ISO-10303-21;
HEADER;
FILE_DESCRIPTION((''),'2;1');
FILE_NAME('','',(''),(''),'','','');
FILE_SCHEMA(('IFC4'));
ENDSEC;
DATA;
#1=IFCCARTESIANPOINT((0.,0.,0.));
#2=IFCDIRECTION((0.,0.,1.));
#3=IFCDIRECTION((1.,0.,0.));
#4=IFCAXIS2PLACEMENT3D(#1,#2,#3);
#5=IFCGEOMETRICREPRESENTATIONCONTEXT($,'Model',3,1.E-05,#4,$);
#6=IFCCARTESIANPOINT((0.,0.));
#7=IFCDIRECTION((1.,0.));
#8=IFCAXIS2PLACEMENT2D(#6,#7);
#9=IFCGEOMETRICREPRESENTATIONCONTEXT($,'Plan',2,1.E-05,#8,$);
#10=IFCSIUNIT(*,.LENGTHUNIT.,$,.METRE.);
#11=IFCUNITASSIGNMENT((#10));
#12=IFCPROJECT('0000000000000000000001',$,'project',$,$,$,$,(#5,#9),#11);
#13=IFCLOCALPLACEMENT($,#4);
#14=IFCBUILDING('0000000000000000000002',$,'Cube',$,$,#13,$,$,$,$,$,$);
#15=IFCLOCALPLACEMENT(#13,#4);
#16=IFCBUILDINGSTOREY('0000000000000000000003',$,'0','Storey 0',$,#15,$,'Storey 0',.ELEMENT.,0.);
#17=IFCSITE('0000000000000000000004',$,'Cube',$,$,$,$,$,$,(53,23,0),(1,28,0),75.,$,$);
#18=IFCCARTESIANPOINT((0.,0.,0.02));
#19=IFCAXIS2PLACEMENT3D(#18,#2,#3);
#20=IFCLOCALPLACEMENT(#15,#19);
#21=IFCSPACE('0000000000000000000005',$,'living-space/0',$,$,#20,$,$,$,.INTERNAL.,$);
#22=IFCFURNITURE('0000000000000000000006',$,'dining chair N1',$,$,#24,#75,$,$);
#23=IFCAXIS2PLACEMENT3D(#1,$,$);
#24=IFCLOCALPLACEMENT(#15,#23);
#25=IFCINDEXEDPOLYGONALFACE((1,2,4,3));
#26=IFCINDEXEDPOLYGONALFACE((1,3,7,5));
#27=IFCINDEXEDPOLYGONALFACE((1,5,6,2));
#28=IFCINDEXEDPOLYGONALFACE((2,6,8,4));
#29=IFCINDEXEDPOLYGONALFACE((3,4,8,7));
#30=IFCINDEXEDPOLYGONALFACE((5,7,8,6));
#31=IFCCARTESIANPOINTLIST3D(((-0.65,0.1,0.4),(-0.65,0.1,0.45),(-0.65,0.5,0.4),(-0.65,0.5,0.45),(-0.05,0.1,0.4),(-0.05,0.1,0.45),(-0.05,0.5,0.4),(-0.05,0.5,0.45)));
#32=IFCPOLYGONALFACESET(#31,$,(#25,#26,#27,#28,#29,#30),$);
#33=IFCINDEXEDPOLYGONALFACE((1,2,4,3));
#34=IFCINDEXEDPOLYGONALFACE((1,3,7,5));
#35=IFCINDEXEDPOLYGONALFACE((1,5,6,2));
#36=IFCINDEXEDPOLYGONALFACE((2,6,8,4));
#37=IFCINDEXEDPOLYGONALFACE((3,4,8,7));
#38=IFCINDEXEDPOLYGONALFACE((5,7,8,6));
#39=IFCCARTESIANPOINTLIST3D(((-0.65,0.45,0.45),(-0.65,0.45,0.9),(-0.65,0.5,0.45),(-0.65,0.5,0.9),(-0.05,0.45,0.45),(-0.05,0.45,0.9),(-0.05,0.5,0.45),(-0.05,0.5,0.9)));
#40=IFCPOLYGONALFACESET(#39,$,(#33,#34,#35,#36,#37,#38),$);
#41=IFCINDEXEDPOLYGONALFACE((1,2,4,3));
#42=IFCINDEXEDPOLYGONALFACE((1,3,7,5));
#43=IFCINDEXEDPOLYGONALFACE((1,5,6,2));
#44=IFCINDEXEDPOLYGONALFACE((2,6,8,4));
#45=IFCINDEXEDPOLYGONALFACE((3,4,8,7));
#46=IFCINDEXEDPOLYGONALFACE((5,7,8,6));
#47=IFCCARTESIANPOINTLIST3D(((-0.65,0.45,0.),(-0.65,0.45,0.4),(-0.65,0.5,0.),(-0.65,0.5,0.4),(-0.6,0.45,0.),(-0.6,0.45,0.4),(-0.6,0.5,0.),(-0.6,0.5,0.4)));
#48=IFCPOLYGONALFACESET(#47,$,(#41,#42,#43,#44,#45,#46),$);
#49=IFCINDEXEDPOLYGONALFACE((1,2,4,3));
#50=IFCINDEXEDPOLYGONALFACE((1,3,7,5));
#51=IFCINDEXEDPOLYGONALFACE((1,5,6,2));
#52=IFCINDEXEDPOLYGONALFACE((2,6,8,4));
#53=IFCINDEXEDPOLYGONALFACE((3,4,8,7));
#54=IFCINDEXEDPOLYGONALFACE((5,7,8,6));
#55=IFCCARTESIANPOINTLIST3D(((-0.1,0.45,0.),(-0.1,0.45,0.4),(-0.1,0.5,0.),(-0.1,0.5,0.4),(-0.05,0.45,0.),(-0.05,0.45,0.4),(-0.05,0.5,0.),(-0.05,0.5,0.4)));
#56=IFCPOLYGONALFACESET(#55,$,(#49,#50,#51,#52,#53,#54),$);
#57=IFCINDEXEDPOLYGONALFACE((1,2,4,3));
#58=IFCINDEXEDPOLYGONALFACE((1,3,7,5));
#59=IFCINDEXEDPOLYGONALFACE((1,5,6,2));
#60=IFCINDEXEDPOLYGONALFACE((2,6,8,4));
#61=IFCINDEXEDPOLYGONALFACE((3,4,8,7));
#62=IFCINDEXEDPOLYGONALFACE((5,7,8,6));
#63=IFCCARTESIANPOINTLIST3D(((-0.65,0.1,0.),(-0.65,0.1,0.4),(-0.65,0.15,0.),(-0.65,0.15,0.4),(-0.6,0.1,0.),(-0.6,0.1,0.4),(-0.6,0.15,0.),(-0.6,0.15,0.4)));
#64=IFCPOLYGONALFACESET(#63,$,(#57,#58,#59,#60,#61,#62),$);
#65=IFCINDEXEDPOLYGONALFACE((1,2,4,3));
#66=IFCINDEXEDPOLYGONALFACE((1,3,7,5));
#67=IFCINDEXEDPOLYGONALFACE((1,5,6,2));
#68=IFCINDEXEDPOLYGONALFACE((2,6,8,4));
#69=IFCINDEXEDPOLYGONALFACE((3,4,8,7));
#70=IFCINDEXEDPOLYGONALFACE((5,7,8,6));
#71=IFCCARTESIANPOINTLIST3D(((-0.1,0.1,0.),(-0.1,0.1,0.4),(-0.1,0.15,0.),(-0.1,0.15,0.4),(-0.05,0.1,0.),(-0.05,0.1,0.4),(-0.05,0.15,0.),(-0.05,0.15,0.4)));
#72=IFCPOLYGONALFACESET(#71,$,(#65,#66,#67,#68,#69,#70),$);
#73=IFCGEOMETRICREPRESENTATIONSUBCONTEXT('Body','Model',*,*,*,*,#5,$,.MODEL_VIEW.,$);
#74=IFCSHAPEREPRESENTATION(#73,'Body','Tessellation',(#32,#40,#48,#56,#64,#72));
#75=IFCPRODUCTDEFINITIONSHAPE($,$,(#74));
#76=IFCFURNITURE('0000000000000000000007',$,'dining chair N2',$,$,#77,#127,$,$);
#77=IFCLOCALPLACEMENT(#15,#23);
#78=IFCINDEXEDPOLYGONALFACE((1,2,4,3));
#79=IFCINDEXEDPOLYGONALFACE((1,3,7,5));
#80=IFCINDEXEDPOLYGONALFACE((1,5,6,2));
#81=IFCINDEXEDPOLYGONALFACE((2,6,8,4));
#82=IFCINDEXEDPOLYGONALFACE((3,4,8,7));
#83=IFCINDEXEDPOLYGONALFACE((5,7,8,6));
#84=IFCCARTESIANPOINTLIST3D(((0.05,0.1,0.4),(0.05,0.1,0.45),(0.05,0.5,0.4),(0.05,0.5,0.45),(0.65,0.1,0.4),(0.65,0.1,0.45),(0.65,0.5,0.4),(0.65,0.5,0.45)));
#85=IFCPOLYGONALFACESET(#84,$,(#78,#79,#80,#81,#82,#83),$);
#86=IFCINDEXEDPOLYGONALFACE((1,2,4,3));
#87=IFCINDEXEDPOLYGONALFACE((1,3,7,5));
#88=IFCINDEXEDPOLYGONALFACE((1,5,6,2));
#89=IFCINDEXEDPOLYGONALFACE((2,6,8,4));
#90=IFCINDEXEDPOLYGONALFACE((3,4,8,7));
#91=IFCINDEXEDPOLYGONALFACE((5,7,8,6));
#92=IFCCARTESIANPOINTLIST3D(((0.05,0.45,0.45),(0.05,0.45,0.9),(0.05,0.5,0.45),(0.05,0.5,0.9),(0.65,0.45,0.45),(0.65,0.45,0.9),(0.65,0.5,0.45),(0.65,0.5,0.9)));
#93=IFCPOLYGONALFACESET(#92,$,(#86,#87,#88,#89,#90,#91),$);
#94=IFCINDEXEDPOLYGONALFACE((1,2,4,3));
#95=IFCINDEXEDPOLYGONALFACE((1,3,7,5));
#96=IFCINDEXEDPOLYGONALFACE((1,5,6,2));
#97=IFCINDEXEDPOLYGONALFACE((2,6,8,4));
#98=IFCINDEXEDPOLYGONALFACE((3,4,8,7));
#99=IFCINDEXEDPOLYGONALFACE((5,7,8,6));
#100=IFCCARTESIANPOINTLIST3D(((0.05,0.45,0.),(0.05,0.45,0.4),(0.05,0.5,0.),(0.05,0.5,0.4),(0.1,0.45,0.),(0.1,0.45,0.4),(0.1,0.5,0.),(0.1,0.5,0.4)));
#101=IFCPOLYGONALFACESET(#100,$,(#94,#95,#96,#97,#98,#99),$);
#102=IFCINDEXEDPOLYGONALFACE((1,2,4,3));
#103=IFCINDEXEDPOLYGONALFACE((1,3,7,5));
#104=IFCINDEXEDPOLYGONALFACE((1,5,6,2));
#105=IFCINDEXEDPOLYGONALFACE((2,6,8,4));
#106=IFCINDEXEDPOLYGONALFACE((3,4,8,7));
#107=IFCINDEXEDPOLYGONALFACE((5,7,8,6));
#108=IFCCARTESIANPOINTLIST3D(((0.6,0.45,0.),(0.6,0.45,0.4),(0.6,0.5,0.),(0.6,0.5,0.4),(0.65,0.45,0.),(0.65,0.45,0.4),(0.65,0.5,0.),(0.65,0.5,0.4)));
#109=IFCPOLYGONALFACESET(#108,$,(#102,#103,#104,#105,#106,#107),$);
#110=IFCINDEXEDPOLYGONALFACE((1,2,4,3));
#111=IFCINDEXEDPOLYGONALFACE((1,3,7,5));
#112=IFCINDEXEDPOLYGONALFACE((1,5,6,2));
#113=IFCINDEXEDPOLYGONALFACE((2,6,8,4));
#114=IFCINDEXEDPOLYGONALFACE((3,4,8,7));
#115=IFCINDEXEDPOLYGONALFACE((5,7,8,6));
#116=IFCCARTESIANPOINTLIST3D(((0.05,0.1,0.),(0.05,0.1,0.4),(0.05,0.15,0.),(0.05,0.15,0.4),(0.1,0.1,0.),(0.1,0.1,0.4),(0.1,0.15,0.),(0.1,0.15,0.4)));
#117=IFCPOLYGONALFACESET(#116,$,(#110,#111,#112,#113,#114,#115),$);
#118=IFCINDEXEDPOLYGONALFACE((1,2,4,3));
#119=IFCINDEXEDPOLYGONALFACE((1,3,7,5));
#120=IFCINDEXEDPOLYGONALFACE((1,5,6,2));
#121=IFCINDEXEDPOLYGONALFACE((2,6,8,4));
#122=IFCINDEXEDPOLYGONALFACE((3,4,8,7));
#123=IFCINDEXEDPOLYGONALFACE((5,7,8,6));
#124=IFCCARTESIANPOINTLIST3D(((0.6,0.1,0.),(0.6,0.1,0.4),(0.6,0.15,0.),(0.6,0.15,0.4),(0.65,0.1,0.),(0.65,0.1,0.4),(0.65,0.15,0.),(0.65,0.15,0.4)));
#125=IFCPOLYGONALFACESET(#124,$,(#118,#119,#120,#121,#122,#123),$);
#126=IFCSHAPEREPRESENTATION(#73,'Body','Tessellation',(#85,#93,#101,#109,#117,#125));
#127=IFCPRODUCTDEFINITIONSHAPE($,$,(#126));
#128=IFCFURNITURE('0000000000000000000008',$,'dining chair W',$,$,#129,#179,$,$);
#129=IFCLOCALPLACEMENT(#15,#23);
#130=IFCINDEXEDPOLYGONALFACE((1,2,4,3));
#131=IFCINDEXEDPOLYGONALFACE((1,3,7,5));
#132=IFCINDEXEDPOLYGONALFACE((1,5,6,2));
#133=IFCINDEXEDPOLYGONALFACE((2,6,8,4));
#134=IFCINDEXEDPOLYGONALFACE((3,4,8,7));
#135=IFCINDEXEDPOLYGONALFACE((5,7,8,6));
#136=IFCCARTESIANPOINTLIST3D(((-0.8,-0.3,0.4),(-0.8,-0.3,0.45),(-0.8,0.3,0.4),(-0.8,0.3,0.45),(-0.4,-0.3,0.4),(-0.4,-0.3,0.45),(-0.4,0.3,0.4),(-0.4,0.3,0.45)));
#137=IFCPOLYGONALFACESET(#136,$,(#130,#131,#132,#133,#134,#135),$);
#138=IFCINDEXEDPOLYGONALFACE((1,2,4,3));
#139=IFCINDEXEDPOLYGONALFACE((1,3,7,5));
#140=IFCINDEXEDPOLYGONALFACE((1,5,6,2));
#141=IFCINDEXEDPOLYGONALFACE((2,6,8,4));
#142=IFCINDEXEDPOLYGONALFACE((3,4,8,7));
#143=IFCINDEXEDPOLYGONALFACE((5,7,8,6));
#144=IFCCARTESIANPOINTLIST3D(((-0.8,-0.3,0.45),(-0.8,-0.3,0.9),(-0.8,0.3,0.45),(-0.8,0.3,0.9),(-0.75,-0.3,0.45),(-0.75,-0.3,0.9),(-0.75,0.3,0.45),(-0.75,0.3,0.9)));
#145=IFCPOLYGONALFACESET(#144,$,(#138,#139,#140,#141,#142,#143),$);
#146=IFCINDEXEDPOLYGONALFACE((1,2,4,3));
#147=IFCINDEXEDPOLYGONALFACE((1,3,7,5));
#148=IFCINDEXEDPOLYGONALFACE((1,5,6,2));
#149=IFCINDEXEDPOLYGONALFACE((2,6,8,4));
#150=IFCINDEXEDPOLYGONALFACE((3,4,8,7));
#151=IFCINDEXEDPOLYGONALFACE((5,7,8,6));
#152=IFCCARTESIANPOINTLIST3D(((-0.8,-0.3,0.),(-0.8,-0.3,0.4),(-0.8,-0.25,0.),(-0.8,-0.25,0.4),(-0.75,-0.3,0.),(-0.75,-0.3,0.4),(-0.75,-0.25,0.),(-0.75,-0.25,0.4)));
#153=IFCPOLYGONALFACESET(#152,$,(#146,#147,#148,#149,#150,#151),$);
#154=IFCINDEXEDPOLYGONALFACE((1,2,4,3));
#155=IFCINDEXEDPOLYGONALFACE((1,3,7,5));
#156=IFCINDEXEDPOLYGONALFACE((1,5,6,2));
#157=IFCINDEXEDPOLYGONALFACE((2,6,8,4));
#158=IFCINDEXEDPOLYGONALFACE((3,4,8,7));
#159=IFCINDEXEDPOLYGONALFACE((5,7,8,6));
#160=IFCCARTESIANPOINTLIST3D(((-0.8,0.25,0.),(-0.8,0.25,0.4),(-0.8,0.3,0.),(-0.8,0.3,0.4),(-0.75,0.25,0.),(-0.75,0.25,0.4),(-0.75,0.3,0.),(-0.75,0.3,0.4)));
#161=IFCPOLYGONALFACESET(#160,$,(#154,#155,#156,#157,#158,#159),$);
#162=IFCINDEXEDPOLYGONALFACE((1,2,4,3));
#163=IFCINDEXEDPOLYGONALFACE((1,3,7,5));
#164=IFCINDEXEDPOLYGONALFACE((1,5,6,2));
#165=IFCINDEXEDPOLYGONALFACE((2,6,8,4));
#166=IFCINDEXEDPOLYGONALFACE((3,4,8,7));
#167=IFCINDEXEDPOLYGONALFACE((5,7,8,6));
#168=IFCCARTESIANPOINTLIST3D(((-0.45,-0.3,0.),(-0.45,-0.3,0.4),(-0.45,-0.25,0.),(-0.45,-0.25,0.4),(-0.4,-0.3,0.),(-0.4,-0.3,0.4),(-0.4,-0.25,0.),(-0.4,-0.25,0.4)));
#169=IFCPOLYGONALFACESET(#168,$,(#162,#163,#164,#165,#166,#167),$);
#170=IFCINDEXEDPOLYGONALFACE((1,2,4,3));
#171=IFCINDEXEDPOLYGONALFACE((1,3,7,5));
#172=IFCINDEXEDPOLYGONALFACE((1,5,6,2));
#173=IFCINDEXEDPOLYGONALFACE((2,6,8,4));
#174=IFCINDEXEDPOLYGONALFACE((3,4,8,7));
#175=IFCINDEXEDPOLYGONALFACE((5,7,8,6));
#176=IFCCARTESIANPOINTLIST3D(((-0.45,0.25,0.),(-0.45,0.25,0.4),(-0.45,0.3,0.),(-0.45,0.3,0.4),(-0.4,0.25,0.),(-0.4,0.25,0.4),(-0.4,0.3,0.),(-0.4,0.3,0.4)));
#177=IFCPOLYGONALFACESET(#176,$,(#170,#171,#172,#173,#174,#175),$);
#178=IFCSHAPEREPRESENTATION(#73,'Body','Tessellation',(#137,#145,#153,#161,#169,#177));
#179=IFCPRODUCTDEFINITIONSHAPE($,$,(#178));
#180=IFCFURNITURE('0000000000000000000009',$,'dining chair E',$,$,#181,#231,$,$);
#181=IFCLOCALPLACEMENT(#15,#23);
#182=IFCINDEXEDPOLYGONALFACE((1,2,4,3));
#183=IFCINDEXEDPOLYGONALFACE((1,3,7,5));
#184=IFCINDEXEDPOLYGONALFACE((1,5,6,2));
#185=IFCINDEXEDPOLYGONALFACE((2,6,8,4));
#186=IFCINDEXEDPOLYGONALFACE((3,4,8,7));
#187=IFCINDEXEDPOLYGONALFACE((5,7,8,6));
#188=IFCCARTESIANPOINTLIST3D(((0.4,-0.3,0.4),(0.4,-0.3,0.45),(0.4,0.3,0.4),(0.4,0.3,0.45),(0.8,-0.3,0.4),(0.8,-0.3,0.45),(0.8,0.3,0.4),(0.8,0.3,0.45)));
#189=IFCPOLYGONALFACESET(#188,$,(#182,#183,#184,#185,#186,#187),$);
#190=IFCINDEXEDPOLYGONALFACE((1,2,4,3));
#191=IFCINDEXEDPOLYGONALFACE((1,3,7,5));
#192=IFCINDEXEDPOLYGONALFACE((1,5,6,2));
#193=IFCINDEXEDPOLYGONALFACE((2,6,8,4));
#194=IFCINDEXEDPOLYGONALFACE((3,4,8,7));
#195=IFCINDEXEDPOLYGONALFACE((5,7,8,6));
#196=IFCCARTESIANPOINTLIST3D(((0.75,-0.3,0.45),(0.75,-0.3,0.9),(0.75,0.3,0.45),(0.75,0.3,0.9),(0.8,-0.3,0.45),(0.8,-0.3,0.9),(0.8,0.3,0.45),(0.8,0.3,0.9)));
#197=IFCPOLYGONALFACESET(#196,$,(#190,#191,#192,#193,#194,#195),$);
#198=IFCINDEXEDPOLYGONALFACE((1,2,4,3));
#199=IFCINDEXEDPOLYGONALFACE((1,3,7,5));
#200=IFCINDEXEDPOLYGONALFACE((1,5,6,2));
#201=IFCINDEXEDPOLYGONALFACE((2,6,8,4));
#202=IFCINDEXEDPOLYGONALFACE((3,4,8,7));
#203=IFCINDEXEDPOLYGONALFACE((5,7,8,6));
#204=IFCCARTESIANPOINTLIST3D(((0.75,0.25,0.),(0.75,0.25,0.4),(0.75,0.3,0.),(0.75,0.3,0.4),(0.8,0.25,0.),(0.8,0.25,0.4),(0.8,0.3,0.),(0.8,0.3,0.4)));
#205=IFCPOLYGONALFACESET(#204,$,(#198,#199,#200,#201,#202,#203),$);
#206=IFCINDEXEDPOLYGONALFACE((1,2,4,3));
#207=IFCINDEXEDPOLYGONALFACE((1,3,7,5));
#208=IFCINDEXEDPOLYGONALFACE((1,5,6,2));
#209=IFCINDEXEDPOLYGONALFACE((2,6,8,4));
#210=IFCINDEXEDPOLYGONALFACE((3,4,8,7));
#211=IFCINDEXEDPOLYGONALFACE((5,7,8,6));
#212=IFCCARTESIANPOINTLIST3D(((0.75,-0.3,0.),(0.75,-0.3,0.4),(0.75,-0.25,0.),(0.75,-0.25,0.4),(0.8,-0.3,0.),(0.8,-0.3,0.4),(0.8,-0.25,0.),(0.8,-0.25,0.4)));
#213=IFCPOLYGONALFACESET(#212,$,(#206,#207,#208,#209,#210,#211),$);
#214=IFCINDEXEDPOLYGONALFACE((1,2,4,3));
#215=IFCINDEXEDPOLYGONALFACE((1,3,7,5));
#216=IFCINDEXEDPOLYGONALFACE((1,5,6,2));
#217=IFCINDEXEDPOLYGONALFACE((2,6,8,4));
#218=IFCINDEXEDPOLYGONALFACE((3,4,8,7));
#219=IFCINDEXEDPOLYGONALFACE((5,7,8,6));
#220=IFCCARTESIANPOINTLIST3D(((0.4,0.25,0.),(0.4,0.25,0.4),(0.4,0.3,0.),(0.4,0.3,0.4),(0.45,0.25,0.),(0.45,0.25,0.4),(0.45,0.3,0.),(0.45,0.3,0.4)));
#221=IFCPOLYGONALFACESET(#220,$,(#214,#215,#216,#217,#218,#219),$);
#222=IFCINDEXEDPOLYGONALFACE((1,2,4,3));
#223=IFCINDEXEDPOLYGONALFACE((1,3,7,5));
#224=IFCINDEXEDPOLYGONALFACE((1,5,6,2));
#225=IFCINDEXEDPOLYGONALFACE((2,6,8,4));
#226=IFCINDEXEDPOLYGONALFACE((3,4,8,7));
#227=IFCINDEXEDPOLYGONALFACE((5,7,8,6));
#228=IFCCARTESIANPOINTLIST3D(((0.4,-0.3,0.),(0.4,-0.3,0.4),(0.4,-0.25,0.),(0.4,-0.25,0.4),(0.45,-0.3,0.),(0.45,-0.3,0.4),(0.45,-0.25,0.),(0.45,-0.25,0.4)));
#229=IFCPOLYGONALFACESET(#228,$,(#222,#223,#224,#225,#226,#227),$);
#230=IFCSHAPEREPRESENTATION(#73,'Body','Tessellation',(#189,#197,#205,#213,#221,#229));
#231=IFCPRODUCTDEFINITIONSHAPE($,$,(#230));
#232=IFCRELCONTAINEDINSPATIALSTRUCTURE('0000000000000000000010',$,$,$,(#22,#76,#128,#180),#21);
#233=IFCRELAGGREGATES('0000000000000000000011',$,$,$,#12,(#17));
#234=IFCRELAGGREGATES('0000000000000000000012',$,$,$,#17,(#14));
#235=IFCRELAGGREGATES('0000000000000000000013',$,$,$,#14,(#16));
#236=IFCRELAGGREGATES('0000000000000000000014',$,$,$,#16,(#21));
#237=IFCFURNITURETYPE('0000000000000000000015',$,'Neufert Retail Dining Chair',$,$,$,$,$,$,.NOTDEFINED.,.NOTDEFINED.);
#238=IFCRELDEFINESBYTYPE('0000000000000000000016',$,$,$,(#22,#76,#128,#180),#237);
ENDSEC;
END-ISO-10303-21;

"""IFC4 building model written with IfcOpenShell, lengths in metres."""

from ifc_helpers import new_model, entity, si_unit, frame, origin_with_axes, origin_2d_with_axis, place, context, subcontext, project, spatial, line, indexed_curve, outline, extrude, shape, source, transform, mapped, type_object, type_shapes, element, save


model = new_model("IFC4")

# Units and contexts
model_context = context("Model", 3, precision=1e-05, world=origin_with_axes())
plan_context = context("Plan", 2, precision=1e-05, world=origin_2d_with_axis())
body_context_1 = subcontext(model_context, "Body", "Model", "MODEL_VIEW")
body_context_2 = subcontext(plan_context, "Body", "Plan", "PLAN_VIEW")
ifc_project = project(units=[si_unit("LENGTHUNIT", "METRE")], contexts=[model_context, plan_context])

# Site, building, storey
site = spatial("IfcSite", under=ifc_project, Name="Cube", RefLatitude=(53, 23, 0), RefLongitude=(1, 28, 0), RefElevation=75.0)
building_placement = place(None, origin_with_axes())
building = spatial("IfcBuilding", under=site, at=building_placement, Name="Cube")
storey_placement = place(building_placement, origin_with_axes())
storey = spatial("IfcBuildingStorey", under=building, at=storey_placement, Name="0", Description="Storey 0", LongName="Storey 0", CompositionType="ELEMENT", Elevation=0.0)

# Shared definitions
space_placement = place(storey_placement, frame((0.0, 0.0, 0.02), z_axis=(0.0, 0.0, 1.0), x_axis=(1.0, 0.0, 0.0)))
space = spatial("IfcSpace", under=storey, at=space_placement, Name="living-space/0", PredefinedType="INTERNAL")

# Furniture
furniture_type_1 = type_object("IfcFurnitureType", Name="Neufert Retail Dining Chair", AssemblyPlace="NOTDEFINED", PredefinedType="NOTDEFINED")
shared_shape_1 = source(origin_with_axes(), body_context_1, "Body", "SweptSolid", [
    extrude(outline(indexed_curve([(-0.3, 0.0), (0.3, 0.0), (0.3, -0.4), (-0.3, -0.4)], segments=[line(1, 2, 3, 4, 1)])), frame((0.0, 0.0, 0.45), z_axis=(0.0, 0.0, 1.0), x_axis=(1.0, 0.0, 0.0)), (0.0, 0.0, -1.0), 0.05),
    extrude(outline(indexed_curve([(-0.3, 0.0), (0.3, 0.0), (0.3, -0.05), (-0.3, -0.05)], segments=[line(1, 2, 3, 4, 1)])), frame((0.0, 0.0, 0.9), z_axis=(0.0, 0.0, 1.0), x_axis=(1.0, 0.0, 0.0)), (0.0, 0.0, -1.0), 0.45),
    extrude(outline(indexed_curve([(-0.3, 0.0), (-0.25, 0.0), (-0.25, -0.05), (-0.3, -0.05)], segments=[line(1, 2, 3, 4, 1)])), origin_with_axes(), (0.0, 0.0, 1.0), 0.4),
    extrude(outline(indexed_curve([(0.3, 0.0), (0.25, 0.0), (0.25, -0.05), (0.3, -0.05)], segments=[line(1, 2, 3, 4, 1)])), origin_with_axes(), (0.0, 0.0, 1.0), 0.4),
    extrude(outline(indexed_curve([(-0.3, -0.4), (-0.25, -0.4), (-0.25, -0.35), (-0.3, -0.35)], segments=[line(1, 2, 3, 4, 1)])), origin_with_axes(), (0.0, 0.0, 1.0), 0.4),
    extrude(outline(indexed_curve([(0.3, -0.4), (0.25, -0.4), (0.25, -0.35), (0.3, -0.35)], segments=[line(1, 2, 3, 4, 1)])), origin_with_axes(), (0.0, 0.0, 1.0), 0.4),
])
shared_shape_2 = source(origin_with_axes(), body_context_2, "Body", "Curve2D", [
    entity("IfcIndexedPolyCurve", entity("IfcCartesianPointList2D", [[-0.3, -0.4], [0.3, -0.4]])),
    entity("IfcIndexedPolyCurve", entity("IfcCartesianPointList2D", [[-0.3, -0.4], [-0.3, -0.3], [-0.2121, -0.0879], [0.0, 0.0], [0.2121, -0.0879], [0.3, -0.3], [0.3, -0.4]]), [entity("IfcLineIndex", [1, 2]), entity("IfcArcIndex", [2, 3, 4]), entity("IfcArcIndex", [4, 5, 6]), entity("IfcLineIndex", [6, 7])]),
    entity("IfcIndexedPolyCurve", entity("IfcCartesianPointList2D", [[-0.26, -0.4], [-0.26, -0.3], [-0.1838, -0.1162], [0.0, -0.04], [0.1838, -0.1162], [0.26, -0.3], [0.26, -0.4]]), [entity("IfcLineIndex", [1, 2]), entity("IfcArcIndex", [2, 3, 4]), entity("IfcArcIndex", [4, 5, 6]), entity("IfcLineIndex", [6, 7])]),
])
type_shapes(furniture_type_1, [shared_shape_1, shared_shape_2])
for number, where, z_axis, x_axis, name in (
    (1, (-0.35, 0.5, -0.02), (0.0, 0.0, 1.0), (1.0, 0.0, 0.0), "dining chair N1"),
    (2, (0.35, 0.5, -0.02), (0.0, 0.0, 1.0), (1.0, 0.0, 0.0), "dining chair N2"),
    (3, (-0.8, 0.0, -0.02), (0.0, 0.0, 1.0), (0.0, 1.0, 0.0), "dining chair W"),
    (4, (0.8, 0.0, -0.02), (0.0, 0.0, 1.0), (0.0, -1.0, 0.0), "dining chair E"),
):
    element("IfcFurniture", number, at=place(space_placement, frame(where, z_axis=z_axis, x_axis=x_axis)), inside=space, type_object=furniture_type_1, Name=name, shapes=[
        shape(body_context_1, "Body", "MappedRepresentation", [mapped(shared_shape_1, transform((0.0, 0.0, 0.0), x_axis=(1.0, 0.0, 0.0), y_axis=(0.0, 1.0, 0.0), z_axis=(0.0, 0.0, 1.0), scale=1.0))]),
        shape(body_context_2, "Body", "MappedRepresentation", [mapped(shared_shape_2, transform((0.0, 0.0, 0.0), x_axis=(1.0, 0.0, 0.0), y_axis=(0.0, 1.0, 0.0), z_axis=(0.0, 0.0, 1.0), scale=1.0))]),
    ])

save(model, "model.ifc")
